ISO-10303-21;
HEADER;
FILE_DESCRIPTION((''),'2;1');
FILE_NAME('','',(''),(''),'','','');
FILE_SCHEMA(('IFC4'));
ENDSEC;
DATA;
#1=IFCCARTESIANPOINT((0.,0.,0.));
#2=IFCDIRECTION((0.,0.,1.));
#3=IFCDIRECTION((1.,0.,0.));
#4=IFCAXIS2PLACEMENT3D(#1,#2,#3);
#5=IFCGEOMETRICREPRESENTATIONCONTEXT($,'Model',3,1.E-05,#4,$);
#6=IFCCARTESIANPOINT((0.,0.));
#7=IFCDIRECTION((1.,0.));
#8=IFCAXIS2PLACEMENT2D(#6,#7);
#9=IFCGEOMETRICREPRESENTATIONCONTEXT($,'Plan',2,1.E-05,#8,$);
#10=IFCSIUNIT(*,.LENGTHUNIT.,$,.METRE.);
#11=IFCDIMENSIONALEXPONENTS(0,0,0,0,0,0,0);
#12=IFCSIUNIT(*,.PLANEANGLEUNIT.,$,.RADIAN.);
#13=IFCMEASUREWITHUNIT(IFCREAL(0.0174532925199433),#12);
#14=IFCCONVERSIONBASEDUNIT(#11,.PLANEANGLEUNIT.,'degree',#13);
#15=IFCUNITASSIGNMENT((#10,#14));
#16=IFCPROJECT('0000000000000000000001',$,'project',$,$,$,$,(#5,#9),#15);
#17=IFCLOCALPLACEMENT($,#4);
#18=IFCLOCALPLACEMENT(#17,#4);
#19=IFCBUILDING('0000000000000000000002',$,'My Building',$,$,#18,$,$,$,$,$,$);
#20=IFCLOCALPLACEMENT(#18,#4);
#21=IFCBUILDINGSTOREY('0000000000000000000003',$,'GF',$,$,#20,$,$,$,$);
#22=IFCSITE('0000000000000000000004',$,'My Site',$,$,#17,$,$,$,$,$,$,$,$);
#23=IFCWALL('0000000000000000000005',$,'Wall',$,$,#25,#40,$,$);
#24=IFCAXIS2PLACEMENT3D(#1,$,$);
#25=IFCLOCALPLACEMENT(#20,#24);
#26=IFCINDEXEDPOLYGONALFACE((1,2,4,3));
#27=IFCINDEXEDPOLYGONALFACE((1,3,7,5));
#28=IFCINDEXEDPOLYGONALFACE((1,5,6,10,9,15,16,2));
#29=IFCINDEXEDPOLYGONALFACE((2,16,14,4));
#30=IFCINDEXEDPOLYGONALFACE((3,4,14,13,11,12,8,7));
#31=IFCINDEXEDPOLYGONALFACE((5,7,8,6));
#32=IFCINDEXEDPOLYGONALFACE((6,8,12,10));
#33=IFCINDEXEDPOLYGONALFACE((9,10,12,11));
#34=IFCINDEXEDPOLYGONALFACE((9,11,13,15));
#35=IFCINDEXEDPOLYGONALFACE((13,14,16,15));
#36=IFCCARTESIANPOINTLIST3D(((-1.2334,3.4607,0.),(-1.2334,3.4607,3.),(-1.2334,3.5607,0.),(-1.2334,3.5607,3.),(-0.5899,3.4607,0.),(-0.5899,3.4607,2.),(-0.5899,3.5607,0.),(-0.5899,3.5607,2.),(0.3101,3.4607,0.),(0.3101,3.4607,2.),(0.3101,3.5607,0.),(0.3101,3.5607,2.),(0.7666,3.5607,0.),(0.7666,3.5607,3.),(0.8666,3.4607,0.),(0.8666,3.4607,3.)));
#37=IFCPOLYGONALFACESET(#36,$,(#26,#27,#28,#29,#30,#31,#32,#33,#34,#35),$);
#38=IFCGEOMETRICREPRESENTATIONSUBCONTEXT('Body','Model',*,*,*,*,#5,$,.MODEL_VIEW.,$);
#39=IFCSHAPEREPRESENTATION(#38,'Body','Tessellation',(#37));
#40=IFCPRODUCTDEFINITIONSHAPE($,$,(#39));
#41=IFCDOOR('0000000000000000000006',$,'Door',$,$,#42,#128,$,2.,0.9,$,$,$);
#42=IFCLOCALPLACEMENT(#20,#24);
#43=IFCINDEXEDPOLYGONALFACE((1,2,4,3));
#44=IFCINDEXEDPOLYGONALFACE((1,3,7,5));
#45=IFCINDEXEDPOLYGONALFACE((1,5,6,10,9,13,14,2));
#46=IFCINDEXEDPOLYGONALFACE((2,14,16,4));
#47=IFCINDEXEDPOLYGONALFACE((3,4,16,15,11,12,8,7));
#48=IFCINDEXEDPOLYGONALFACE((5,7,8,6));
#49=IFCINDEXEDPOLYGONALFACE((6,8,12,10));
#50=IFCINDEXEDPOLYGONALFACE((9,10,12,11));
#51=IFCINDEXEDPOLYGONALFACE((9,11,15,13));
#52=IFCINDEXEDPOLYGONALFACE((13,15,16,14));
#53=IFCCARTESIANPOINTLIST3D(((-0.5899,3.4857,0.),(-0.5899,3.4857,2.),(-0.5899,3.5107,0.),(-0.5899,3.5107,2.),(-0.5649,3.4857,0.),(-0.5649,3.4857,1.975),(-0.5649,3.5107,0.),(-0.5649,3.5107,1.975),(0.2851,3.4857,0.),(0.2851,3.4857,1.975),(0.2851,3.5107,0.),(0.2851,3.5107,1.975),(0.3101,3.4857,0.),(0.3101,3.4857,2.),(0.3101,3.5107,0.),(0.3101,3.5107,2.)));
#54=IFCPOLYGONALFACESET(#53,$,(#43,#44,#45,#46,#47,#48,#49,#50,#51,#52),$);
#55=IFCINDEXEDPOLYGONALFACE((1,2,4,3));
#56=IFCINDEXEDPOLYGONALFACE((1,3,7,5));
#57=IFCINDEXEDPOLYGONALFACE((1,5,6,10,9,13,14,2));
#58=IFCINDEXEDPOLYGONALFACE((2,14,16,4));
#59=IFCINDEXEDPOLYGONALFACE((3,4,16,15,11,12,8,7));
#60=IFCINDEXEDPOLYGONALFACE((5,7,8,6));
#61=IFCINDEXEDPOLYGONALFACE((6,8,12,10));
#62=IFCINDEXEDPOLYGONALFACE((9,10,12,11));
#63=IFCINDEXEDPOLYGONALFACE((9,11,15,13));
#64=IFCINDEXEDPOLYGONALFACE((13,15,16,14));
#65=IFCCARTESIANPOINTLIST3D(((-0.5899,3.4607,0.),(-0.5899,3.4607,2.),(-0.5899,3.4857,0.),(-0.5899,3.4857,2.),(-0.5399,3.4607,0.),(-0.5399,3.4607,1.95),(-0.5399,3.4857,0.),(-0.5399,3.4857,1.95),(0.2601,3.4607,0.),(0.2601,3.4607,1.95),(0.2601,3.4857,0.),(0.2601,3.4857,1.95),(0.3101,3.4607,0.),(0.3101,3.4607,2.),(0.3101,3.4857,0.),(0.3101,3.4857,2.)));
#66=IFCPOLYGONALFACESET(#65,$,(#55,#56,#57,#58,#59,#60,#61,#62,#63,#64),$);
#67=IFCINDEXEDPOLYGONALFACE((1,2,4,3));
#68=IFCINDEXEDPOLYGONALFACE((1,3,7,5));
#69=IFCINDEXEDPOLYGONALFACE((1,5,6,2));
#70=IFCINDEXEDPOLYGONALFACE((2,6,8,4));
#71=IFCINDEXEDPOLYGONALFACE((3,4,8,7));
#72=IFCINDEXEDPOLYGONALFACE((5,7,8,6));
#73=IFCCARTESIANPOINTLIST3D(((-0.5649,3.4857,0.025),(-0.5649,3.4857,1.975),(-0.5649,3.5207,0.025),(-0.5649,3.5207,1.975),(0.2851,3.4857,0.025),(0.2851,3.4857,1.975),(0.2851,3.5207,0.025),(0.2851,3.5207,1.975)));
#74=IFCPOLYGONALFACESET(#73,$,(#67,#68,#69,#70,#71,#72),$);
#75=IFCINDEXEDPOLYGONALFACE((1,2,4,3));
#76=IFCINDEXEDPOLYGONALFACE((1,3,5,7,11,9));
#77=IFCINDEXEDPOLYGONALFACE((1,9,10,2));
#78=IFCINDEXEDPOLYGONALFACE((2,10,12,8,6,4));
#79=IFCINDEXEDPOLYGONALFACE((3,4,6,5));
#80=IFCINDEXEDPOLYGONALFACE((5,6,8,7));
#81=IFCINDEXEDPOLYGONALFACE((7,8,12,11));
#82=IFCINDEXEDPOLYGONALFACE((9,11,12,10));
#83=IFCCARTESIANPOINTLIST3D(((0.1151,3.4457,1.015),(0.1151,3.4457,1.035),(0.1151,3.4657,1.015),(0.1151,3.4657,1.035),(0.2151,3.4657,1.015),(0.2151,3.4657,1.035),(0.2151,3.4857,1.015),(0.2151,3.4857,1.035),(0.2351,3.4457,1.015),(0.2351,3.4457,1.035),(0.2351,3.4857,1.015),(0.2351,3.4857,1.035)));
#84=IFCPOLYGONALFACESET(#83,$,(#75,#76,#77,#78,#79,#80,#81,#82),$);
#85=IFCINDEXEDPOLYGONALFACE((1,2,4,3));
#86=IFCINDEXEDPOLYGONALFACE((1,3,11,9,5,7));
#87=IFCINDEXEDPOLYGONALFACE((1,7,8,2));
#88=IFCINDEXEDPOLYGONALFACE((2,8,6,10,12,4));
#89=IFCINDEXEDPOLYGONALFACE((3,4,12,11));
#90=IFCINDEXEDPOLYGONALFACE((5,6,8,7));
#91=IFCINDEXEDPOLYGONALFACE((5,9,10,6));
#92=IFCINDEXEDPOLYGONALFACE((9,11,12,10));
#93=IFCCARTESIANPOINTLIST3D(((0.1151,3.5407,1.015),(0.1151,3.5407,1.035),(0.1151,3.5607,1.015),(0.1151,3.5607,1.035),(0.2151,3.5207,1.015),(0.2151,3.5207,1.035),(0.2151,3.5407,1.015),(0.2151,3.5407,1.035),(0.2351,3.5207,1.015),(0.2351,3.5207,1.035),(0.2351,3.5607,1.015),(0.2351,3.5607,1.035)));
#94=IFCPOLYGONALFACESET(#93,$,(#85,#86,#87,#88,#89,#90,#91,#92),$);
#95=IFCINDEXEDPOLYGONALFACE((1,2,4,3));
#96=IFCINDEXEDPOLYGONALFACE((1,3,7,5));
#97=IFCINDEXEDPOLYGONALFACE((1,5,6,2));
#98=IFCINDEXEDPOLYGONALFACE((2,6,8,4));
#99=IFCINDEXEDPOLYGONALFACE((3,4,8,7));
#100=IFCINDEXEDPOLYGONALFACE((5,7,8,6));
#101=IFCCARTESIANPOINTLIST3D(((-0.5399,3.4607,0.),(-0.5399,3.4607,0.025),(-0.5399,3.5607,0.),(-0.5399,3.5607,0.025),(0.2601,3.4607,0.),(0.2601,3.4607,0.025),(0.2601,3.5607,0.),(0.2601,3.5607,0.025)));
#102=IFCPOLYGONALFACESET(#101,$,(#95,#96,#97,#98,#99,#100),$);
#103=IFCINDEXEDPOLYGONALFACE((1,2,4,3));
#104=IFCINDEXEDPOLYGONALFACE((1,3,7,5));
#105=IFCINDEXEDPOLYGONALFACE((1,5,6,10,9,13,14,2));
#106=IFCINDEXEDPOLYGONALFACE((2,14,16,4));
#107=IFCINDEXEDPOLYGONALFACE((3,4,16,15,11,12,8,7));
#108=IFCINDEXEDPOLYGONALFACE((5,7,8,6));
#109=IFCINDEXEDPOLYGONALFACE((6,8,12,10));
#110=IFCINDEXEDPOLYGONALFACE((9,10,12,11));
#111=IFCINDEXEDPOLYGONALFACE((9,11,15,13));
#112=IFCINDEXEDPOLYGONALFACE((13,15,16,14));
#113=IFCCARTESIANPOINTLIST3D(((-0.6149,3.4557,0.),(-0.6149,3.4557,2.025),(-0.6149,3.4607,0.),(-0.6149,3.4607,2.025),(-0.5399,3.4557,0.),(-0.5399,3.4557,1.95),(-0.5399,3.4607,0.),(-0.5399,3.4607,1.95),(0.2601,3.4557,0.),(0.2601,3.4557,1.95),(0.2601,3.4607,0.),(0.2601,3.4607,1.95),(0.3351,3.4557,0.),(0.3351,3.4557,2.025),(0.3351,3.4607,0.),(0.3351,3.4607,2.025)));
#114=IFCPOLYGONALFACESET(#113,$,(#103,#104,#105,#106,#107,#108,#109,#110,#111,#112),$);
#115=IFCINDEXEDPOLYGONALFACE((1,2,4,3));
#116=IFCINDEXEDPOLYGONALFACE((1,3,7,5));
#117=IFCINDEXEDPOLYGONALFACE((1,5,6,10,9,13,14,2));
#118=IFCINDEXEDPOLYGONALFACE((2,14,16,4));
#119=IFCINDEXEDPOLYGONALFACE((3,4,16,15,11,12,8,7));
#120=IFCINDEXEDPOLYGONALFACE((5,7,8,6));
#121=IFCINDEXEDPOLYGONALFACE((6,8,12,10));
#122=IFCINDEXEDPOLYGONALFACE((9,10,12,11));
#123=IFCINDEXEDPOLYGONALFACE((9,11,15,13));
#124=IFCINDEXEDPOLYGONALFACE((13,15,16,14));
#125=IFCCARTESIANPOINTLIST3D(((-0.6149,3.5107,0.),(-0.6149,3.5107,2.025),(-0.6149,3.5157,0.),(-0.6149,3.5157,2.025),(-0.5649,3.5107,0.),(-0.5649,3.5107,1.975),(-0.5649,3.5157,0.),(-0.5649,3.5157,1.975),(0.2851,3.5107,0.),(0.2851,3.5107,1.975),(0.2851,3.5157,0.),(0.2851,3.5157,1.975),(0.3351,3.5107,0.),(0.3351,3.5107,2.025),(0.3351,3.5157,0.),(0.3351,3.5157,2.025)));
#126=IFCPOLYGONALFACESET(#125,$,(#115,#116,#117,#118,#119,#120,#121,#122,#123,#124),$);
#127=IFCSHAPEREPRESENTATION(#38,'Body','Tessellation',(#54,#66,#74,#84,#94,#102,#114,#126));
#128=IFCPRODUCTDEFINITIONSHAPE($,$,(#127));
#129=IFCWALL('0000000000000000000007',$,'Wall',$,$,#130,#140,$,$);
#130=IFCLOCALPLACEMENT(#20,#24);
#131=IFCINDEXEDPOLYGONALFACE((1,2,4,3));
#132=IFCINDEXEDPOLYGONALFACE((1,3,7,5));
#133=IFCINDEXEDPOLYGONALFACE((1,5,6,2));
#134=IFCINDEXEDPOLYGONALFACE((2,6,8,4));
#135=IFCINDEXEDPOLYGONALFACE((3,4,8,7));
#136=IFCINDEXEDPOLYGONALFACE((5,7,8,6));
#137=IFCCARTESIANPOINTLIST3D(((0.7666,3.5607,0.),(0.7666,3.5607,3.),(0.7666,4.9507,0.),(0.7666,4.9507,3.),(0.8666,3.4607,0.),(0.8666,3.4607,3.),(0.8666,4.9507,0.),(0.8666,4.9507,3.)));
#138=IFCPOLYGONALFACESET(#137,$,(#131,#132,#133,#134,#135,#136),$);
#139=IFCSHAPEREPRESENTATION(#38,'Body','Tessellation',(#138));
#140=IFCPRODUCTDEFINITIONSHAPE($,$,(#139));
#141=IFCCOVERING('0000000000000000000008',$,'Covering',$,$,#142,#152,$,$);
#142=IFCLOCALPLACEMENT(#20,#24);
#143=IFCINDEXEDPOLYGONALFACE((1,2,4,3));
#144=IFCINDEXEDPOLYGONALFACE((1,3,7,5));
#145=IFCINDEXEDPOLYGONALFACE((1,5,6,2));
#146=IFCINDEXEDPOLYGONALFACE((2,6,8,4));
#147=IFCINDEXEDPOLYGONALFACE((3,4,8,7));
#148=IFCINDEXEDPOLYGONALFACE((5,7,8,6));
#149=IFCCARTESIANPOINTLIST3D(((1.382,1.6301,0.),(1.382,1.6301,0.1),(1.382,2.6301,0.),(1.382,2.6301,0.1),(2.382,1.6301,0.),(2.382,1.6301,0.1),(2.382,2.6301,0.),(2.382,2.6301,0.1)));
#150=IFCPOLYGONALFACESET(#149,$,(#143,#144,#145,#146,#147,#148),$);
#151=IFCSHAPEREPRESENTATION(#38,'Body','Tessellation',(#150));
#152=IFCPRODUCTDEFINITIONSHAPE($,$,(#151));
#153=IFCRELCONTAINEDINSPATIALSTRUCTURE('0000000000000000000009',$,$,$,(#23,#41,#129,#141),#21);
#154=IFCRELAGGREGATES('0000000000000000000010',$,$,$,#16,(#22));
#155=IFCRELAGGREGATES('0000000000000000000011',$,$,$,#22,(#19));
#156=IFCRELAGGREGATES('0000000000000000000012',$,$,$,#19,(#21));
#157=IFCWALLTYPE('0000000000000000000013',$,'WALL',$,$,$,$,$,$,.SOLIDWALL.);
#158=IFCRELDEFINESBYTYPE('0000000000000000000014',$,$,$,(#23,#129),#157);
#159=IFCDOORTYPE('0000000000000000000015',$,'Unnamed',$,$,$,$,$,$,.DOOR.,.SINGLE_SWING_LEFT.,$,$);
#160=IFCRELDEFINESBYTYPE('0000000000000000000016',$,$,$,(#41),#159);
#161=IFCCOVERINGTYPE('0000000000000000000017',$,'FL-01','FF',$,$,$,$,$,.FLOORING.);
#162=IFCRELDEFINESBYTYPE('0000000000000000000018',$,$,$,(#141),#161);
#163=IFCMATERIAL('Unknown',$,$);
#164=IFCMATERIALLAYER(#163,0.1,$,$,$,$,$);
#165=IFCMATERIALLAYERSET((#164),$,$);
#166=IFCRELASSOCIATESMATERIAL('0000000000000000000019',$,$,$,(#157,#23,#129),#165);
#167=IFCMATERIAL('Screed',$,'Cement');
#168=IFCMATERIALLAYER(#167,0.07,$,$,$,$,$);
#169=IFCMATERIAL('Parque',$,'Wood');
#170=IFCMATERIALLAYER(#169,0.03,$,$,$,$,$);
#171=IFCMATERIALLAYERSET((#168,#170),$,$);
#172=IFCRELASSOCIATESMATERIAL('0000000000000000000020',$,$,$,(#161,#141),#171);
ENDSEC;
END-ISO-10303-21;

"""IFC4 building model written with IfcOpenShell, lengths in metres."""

from ifc_helpers import new_model, entity, si_unit, converted_unit, frame, origin_with_axes, origin_2d_with_axis, place, context, subcontext, project, spatial, line, indexed_curve, outline, extrude, shape, source, transform, mapped, material, layer, layer_set, layer_usage, type_object, type_shapes, element, fill, save


model = new_model("IFC4")

# Units and contexts
model_context = context("Model", 3, precision=1e-05, world=origin_with_axes())
plan_context = context("Plan", 2, precision=1e-05, world=origin_2d_with_axis())
body_context_1 = subcontext(model_context, "Body", "Model", "MODEL_VIEW")
body_context_2 = subcontext(plan_context, "Body", "Plan", "PLAN_VIEW")
ifc_project = project(units=[si_unit("LENGTHUNIT", "METRE"), converted_unit("PLANEANGLEUNIT", "degree", entity("IfcReal", 0.0174532925199433), si_unit("PLANEANGLEUNIT", "RADIAN"), dimensions=[0, 0, 0, 0, 0, 0, 0])], contexts=[model_context, plan_context])

# Site, building, storey
site_placement = place(None, origin_with_axes())
site = spatial("IfcSite", under=ifc_project, at=site_placement, Name="My Site")
building_placement = place(site_placement, origin_with_axes())
building = spatial("IfcBuilding", under=site, at=building_placement, Name="My Building")
storey_placement = place(building_placement, origin_with_axes())
storey = spatial("IfcBuildingStorey", under=building, at=storey_placement, Name="GF")

# Shared definitions
ifc_material_1 = material(Name="Unknown")
ifc_layer_1 = layer(ifc_material_1, 0.1)
ifc_layer_set_1 = layer_set([ifc_layer_1])
wall_type = type_object("IfcWallType", Name="WALL", PredefinedType="SOLIDWALL", material=ifc_layer_set_1)

# Wall, opening, door
shared_shape_1 = source(origin_with_axes(), body_context_1, "Body", "SweptSolid", [
    extrude(outline(indexed_curve([(0.0, 0.0), (0.9, 0.0), (0.9, 2.0), (0.0, 2.0)], segments=[line(1, 2, 3, 4, 1)])), frame((0.0, -0.6, 0.0), z_axis=(0.0, -1.0, 0.0), x_axis=(1.0, 0.0, 0.0)), (0.0, 0.0, -1.0), 1.2),
])
door_type = type_object("IfcDoorType", Name="Unnamed", OperationType="SINGLE_SWING_LEFT", PredefinedType="DOOR")
shared_shape_2 = source(origin_with_axes(), body_context_1, "Body", "SweptSolid", [
    extrude(outline(indexed_curve([(0.0, 0.0), (0.0, 2.0), (0.9, 2.0), (0.9, 0.0), (0.875, 0.0), (0.875, 1.975), (0.025, 1.975), (0.025, 0.0)], segments=[line(1, 2, 3, 4, 5, 6, 7, 8, 1)])), frame((0.0, 0.025, 0.0), z_axis=(0.0, -1.0, 0.0), x_axis=(1.0, 0.0, 0.0)), (0.0, 0.0, -1.0), 0.025),
    extrude(outline(indexed_curve([(0.0, 0.0), (0.0, 2.0), (0.9, 2.0), (0.9, 0.0), (0.85, 0.0), (0.85, 1.95), (0.05, 1.95), (0.05, 0.0)], segments=[line(1, 2, 3, 4, 5, 6, 7, 8, 1)])), frame((0.0, 0.0, 0.0), z_axis=(0.0, -1.0, 0.0), x_axis=(1.0, 0.0, 0.0)), (0.0, 0.0, -1.0), 0.025),
    extrude(outline(indexed_curve([(0.0, 0.0), (0.85, 0.0), (0.85, 0.035), (0.0, 0.035)], segments=[line(1, 2, 3, 4, 1)])), frame((0.025, 0.025, 0.025), z_axis=(0.0, 0.0, 1.0), x_axis=(1.0, 0.0, 0.0)), (0.0, 0.0, 1.0), 1.95),
    extrude(outline(indexed_curve([(0.0, 0.0), (0.0, -0.04), (-0.12, -0.04), (-0.12, -0.02), (-0.02, -0.02), (-0.02, 0.0)], segments=[line(1, 2, 3, 4, 5, 6, 1)])), frame((0.825, 0.025, 1.015), z_axis=(0.0, 0.0, 1.0), x_axis=(1.0, 0.0, 0.0)), (0.0, 0.0, 1.0), 0.02),
    extrude(outline(indexed_curve([(0.0, 0.0), (0.0, 0.04), (-0.12, 0.04), (-0.12, 0.02), (-0.02, 0.02), (-0.02, 0.0)], segments=[line(1, 2, 3, 4, 5, 6, 1)])), frame((0.825, 0.06, 1.015), z_axis=(0.0, 0.0, 1.0), x_axis=(1.0, 0.0, 0.0)), (0.0, 0.0, 1.0), 0.02),
    extrude(outline(indexed_curve([(0.0, 0.0), (0.8, 0.0), (0.8, 0.1), (0.0, 0.1)], segments=[line(1, 2, 3, 4, 1)])), frame((0.05, 0.0, 0.0), z_axis=(0.0, 0.0, 1.0), x_axis=(1.0, 0.0, 0.0)), (0.0, 0.0, 1.0), 0.025),
    extrude(outline(indexed_curve([(0.0, 0.0), (0.0, 2.025), (0.95, 2.025), (0.95, 0.0), (0.875, 0.0), (0.875, 1.95), (0.075, 1.95), (0.075, 0.0)], segments=[line(1, 2, 3, 4, 5, 6, 7, 8, 1)])), frame((-0.025, -0.005, 0.0), z_axis=(0.0, -1.0, 0.0), x_axis=(1.0, 0.0, 0.0)), (0.0, 0.0, -1.0), 0.005),
    extrude(outline(indexed_curve([(0.0, 0.0), (0.0, 2.025), (0.95, 2.025), (0.95, 0.0), (0.9, 0.0), (0.9, 1.975), (0.05, 1.975), (0.05, 0.0)], segments=[line(1, 2, 3, 4, 5, 6, 7, 8, 1)])), frame((-0.025, 0.05, 0.0), z_axis=(0.0, -1.0, 0.0), x_axis=(1.0, 0.0, 0.0)), (0.0, 0.0, -1.0), 0.005),
])
shared_shape_3 = source(origin_with_axes(), body_context_2, "Body", "Curve2D", [
    entity("IfcIndexedPolyCurve", entity("IfcCartesianPointList2D", [[0.0, 0.0], [0.0, 0.05], [0.025, 0.05], [0.025, 0.025], [0.05, 0.025], [0.05, 0.0]]), [entity("IfcLineIndex", [1, 2, 3, 4, 5, 6, 1])]),
    entity("IfcIndexedPolyCurve", entity("IfcCartesianPointList2D", [[0.9, 0.0], [0.9, 0.05], [0.875, 0.05], [0.875, 0.025], [0.85, 0.025], [0.85, 0.0]]), [entity("IfcLineIndex", [1, 2, 3, 4, 5, 6, 1])]),
    entity("IfcTrimmedCurve", entity("IfcEllipse", entity("IfcAxis2Placement2D", entity("IfcCartesianPoint", [0.06, 0.05]), entity("IfcDirection", [1.0, 0.0])), 0.815, 0.85), [entity("IfcCartesianPoint", [0.875, 0.05])], [entity("IfcCartesianPoint", [0.06, 0.9])], True, "CARTESIAN"),
    entity("IfcIndexedPolyCurve", entity("IfcCartesianPointList2D", [[0.025, 0.05], [0.06, 0.05], [0.06, 0.9], [0.025, 0.9]]), [entity("IfcLineIndex", [1, 2, 3, 4, 1])]),
])
type_shapes(door_type, [shared_shape_2, shared_shape_3])
ifc_layer_usage_1 = layer_usage(ifc_layer_set_1, "AXIS2", "POSITIVE", 0.0)
wall_1_placement = place(storey_placement, frame((-1.2334, 3.4607, 0.0), z_axis=(0.0, 0.0, 1.0), x_axis=(1.0, 0.0, 0.0)))
wall_1 = element("IfcWall", 1, at=wall_1_placement, inside=storey, type_object=wall_type, material=ifc_layer_usage_1, Name="Wall", context=body_context_1, shape_type="SweptSolid", body=[
    extrude(outline(indexed_curve([(0.0, 0.0), (0.0, 0.1), (2.0, 0.1), (2.1, 0.0)], segments=[line(1, 2, 3, 4, 1)])), origin_with_axes(), (0.0, 0.0, 1.0), 3.0),
])
opening_1_placement = place(wall_1_placement, frame((0.6435, 0.0, 0.0), z_axis=(0.0, 0.0, 1.0), x_axis=(1.0, 0.0, 0.0)))
opening_1 = element("IfcOpeningElement", 2, at=opening_1_placement, cuts=wall_1, PredefinedType="OPENING", context=body_context_1, shape_type="MappedRepresentation", body=[
    mapped(shared_shape_1, transform((0.0, 0.0, 0.0), x_axis=(1.0, 0.0, 0.0), y_axis=(0.0, 1.0, 0.0), z_axis=(0.0, 0.0, 1.0), scale=1.0)),
])
door_1_placement = place(opening_1_placement, origin_with_axes())
door_1 = element("IfcDoor", 3, at=door_1_placement, inside=storey, type_object=door_type, Name="Door", OverallHeight=2.0, OverallWidth=0.9, shapes=[
    shape(body_context_1, "Body", "MappedRepresentation", [mapped(shared_shape_2, transform((0.0, 0.0, 0.0), x_axis=(1.0, 0.0, 0.0), y_axis=(0.0, 1.0, 0.0), z_axis=(0.0, 0.0, 1.0), scale=1.0))]),
    shape(body_context_2, "Body", "MappedRepresentation", [mapped(shared_shape_3, transform((0.0, 0.0, 0.0), x_axis=(1.0, 0.0, 0.0), y_axis=(0.0, 1.0, 0.0), z_axis=(0.0, 0.0, 1.0), scale=1.0))]),
])
fill(opening_1, door_1)

# Wall
ifc_layer_usage_2 = layer_usage(ifc_layer_set_1, "AXIS2", "POSITIVE", 0.0)
wall_2_placement = place(storey_placement, frame((0.8666, 3.4607, 0.0), z_axis=(0.0, 0.0, 1.0), x_axis=(0.0, 1.0, 0.0)))
element("IfcWall", 4, at=wall_2_placement, inside=storey, type_object=wall_type, material=ifc_layer_usage_2, Name="Wall", context=body_context_1, shape_type="SweptSolid", body=[
    extrude(outline(indexed_curve([(0.0, 0.0), (0.1, 0.1), (1.49, 0.1), (1.49, 0.0)], segments=[line(1, 2, 3, 4, 1)])), origin_with_axes(), (0.0, 0.0, 1.0), 3.0),
])

# Covering
ifc_material_2 = material(Name="Screed", Category="Cement")
ifc_layer_2 = layer(ifc_material_2, 0.07)
ifc_material_3 = material(Name="Parque", Category="Wood")
ifc_layer_3 = layer(ifc_material_3, 0.03)
ifc_layer_set_2 = layer_set([ifc_layer_2, ifc_layer_3])
ifc_layer_usage_3 = layer_usage(ifc_layer_set_2, "AXIS3", "POSITIVE", 0.0)
covering_type = type_object("IfcCoveringType", Name="FL-01", Description="FF", PredefinedType="FLOORING", material=ifc_layer_set_2)
covering_placement = place(storey_placement, frame((1.382, 1.6301, 0.0), z_axis=(0.0, 0.0, 1.0), x_axis=(1.0, 0.0, 0.0)))
element("IfcCovering", 5, at=covering_placement, inside=storey, type_object=covering_type, material=ifc_layer_usage_3, Name="Covering", context=body_context_1, shape_type="SweptSolid", body=[
    extrude(outline(indexed_curve([(0.0, 0.0), (1.0, 0.0), (1.0, 1.0), (0.0, 1.0), (0.0, 0.0)])), None, (0.0, 0.0, 1.0), 0.1),
])

save(model, "model.ifc")
